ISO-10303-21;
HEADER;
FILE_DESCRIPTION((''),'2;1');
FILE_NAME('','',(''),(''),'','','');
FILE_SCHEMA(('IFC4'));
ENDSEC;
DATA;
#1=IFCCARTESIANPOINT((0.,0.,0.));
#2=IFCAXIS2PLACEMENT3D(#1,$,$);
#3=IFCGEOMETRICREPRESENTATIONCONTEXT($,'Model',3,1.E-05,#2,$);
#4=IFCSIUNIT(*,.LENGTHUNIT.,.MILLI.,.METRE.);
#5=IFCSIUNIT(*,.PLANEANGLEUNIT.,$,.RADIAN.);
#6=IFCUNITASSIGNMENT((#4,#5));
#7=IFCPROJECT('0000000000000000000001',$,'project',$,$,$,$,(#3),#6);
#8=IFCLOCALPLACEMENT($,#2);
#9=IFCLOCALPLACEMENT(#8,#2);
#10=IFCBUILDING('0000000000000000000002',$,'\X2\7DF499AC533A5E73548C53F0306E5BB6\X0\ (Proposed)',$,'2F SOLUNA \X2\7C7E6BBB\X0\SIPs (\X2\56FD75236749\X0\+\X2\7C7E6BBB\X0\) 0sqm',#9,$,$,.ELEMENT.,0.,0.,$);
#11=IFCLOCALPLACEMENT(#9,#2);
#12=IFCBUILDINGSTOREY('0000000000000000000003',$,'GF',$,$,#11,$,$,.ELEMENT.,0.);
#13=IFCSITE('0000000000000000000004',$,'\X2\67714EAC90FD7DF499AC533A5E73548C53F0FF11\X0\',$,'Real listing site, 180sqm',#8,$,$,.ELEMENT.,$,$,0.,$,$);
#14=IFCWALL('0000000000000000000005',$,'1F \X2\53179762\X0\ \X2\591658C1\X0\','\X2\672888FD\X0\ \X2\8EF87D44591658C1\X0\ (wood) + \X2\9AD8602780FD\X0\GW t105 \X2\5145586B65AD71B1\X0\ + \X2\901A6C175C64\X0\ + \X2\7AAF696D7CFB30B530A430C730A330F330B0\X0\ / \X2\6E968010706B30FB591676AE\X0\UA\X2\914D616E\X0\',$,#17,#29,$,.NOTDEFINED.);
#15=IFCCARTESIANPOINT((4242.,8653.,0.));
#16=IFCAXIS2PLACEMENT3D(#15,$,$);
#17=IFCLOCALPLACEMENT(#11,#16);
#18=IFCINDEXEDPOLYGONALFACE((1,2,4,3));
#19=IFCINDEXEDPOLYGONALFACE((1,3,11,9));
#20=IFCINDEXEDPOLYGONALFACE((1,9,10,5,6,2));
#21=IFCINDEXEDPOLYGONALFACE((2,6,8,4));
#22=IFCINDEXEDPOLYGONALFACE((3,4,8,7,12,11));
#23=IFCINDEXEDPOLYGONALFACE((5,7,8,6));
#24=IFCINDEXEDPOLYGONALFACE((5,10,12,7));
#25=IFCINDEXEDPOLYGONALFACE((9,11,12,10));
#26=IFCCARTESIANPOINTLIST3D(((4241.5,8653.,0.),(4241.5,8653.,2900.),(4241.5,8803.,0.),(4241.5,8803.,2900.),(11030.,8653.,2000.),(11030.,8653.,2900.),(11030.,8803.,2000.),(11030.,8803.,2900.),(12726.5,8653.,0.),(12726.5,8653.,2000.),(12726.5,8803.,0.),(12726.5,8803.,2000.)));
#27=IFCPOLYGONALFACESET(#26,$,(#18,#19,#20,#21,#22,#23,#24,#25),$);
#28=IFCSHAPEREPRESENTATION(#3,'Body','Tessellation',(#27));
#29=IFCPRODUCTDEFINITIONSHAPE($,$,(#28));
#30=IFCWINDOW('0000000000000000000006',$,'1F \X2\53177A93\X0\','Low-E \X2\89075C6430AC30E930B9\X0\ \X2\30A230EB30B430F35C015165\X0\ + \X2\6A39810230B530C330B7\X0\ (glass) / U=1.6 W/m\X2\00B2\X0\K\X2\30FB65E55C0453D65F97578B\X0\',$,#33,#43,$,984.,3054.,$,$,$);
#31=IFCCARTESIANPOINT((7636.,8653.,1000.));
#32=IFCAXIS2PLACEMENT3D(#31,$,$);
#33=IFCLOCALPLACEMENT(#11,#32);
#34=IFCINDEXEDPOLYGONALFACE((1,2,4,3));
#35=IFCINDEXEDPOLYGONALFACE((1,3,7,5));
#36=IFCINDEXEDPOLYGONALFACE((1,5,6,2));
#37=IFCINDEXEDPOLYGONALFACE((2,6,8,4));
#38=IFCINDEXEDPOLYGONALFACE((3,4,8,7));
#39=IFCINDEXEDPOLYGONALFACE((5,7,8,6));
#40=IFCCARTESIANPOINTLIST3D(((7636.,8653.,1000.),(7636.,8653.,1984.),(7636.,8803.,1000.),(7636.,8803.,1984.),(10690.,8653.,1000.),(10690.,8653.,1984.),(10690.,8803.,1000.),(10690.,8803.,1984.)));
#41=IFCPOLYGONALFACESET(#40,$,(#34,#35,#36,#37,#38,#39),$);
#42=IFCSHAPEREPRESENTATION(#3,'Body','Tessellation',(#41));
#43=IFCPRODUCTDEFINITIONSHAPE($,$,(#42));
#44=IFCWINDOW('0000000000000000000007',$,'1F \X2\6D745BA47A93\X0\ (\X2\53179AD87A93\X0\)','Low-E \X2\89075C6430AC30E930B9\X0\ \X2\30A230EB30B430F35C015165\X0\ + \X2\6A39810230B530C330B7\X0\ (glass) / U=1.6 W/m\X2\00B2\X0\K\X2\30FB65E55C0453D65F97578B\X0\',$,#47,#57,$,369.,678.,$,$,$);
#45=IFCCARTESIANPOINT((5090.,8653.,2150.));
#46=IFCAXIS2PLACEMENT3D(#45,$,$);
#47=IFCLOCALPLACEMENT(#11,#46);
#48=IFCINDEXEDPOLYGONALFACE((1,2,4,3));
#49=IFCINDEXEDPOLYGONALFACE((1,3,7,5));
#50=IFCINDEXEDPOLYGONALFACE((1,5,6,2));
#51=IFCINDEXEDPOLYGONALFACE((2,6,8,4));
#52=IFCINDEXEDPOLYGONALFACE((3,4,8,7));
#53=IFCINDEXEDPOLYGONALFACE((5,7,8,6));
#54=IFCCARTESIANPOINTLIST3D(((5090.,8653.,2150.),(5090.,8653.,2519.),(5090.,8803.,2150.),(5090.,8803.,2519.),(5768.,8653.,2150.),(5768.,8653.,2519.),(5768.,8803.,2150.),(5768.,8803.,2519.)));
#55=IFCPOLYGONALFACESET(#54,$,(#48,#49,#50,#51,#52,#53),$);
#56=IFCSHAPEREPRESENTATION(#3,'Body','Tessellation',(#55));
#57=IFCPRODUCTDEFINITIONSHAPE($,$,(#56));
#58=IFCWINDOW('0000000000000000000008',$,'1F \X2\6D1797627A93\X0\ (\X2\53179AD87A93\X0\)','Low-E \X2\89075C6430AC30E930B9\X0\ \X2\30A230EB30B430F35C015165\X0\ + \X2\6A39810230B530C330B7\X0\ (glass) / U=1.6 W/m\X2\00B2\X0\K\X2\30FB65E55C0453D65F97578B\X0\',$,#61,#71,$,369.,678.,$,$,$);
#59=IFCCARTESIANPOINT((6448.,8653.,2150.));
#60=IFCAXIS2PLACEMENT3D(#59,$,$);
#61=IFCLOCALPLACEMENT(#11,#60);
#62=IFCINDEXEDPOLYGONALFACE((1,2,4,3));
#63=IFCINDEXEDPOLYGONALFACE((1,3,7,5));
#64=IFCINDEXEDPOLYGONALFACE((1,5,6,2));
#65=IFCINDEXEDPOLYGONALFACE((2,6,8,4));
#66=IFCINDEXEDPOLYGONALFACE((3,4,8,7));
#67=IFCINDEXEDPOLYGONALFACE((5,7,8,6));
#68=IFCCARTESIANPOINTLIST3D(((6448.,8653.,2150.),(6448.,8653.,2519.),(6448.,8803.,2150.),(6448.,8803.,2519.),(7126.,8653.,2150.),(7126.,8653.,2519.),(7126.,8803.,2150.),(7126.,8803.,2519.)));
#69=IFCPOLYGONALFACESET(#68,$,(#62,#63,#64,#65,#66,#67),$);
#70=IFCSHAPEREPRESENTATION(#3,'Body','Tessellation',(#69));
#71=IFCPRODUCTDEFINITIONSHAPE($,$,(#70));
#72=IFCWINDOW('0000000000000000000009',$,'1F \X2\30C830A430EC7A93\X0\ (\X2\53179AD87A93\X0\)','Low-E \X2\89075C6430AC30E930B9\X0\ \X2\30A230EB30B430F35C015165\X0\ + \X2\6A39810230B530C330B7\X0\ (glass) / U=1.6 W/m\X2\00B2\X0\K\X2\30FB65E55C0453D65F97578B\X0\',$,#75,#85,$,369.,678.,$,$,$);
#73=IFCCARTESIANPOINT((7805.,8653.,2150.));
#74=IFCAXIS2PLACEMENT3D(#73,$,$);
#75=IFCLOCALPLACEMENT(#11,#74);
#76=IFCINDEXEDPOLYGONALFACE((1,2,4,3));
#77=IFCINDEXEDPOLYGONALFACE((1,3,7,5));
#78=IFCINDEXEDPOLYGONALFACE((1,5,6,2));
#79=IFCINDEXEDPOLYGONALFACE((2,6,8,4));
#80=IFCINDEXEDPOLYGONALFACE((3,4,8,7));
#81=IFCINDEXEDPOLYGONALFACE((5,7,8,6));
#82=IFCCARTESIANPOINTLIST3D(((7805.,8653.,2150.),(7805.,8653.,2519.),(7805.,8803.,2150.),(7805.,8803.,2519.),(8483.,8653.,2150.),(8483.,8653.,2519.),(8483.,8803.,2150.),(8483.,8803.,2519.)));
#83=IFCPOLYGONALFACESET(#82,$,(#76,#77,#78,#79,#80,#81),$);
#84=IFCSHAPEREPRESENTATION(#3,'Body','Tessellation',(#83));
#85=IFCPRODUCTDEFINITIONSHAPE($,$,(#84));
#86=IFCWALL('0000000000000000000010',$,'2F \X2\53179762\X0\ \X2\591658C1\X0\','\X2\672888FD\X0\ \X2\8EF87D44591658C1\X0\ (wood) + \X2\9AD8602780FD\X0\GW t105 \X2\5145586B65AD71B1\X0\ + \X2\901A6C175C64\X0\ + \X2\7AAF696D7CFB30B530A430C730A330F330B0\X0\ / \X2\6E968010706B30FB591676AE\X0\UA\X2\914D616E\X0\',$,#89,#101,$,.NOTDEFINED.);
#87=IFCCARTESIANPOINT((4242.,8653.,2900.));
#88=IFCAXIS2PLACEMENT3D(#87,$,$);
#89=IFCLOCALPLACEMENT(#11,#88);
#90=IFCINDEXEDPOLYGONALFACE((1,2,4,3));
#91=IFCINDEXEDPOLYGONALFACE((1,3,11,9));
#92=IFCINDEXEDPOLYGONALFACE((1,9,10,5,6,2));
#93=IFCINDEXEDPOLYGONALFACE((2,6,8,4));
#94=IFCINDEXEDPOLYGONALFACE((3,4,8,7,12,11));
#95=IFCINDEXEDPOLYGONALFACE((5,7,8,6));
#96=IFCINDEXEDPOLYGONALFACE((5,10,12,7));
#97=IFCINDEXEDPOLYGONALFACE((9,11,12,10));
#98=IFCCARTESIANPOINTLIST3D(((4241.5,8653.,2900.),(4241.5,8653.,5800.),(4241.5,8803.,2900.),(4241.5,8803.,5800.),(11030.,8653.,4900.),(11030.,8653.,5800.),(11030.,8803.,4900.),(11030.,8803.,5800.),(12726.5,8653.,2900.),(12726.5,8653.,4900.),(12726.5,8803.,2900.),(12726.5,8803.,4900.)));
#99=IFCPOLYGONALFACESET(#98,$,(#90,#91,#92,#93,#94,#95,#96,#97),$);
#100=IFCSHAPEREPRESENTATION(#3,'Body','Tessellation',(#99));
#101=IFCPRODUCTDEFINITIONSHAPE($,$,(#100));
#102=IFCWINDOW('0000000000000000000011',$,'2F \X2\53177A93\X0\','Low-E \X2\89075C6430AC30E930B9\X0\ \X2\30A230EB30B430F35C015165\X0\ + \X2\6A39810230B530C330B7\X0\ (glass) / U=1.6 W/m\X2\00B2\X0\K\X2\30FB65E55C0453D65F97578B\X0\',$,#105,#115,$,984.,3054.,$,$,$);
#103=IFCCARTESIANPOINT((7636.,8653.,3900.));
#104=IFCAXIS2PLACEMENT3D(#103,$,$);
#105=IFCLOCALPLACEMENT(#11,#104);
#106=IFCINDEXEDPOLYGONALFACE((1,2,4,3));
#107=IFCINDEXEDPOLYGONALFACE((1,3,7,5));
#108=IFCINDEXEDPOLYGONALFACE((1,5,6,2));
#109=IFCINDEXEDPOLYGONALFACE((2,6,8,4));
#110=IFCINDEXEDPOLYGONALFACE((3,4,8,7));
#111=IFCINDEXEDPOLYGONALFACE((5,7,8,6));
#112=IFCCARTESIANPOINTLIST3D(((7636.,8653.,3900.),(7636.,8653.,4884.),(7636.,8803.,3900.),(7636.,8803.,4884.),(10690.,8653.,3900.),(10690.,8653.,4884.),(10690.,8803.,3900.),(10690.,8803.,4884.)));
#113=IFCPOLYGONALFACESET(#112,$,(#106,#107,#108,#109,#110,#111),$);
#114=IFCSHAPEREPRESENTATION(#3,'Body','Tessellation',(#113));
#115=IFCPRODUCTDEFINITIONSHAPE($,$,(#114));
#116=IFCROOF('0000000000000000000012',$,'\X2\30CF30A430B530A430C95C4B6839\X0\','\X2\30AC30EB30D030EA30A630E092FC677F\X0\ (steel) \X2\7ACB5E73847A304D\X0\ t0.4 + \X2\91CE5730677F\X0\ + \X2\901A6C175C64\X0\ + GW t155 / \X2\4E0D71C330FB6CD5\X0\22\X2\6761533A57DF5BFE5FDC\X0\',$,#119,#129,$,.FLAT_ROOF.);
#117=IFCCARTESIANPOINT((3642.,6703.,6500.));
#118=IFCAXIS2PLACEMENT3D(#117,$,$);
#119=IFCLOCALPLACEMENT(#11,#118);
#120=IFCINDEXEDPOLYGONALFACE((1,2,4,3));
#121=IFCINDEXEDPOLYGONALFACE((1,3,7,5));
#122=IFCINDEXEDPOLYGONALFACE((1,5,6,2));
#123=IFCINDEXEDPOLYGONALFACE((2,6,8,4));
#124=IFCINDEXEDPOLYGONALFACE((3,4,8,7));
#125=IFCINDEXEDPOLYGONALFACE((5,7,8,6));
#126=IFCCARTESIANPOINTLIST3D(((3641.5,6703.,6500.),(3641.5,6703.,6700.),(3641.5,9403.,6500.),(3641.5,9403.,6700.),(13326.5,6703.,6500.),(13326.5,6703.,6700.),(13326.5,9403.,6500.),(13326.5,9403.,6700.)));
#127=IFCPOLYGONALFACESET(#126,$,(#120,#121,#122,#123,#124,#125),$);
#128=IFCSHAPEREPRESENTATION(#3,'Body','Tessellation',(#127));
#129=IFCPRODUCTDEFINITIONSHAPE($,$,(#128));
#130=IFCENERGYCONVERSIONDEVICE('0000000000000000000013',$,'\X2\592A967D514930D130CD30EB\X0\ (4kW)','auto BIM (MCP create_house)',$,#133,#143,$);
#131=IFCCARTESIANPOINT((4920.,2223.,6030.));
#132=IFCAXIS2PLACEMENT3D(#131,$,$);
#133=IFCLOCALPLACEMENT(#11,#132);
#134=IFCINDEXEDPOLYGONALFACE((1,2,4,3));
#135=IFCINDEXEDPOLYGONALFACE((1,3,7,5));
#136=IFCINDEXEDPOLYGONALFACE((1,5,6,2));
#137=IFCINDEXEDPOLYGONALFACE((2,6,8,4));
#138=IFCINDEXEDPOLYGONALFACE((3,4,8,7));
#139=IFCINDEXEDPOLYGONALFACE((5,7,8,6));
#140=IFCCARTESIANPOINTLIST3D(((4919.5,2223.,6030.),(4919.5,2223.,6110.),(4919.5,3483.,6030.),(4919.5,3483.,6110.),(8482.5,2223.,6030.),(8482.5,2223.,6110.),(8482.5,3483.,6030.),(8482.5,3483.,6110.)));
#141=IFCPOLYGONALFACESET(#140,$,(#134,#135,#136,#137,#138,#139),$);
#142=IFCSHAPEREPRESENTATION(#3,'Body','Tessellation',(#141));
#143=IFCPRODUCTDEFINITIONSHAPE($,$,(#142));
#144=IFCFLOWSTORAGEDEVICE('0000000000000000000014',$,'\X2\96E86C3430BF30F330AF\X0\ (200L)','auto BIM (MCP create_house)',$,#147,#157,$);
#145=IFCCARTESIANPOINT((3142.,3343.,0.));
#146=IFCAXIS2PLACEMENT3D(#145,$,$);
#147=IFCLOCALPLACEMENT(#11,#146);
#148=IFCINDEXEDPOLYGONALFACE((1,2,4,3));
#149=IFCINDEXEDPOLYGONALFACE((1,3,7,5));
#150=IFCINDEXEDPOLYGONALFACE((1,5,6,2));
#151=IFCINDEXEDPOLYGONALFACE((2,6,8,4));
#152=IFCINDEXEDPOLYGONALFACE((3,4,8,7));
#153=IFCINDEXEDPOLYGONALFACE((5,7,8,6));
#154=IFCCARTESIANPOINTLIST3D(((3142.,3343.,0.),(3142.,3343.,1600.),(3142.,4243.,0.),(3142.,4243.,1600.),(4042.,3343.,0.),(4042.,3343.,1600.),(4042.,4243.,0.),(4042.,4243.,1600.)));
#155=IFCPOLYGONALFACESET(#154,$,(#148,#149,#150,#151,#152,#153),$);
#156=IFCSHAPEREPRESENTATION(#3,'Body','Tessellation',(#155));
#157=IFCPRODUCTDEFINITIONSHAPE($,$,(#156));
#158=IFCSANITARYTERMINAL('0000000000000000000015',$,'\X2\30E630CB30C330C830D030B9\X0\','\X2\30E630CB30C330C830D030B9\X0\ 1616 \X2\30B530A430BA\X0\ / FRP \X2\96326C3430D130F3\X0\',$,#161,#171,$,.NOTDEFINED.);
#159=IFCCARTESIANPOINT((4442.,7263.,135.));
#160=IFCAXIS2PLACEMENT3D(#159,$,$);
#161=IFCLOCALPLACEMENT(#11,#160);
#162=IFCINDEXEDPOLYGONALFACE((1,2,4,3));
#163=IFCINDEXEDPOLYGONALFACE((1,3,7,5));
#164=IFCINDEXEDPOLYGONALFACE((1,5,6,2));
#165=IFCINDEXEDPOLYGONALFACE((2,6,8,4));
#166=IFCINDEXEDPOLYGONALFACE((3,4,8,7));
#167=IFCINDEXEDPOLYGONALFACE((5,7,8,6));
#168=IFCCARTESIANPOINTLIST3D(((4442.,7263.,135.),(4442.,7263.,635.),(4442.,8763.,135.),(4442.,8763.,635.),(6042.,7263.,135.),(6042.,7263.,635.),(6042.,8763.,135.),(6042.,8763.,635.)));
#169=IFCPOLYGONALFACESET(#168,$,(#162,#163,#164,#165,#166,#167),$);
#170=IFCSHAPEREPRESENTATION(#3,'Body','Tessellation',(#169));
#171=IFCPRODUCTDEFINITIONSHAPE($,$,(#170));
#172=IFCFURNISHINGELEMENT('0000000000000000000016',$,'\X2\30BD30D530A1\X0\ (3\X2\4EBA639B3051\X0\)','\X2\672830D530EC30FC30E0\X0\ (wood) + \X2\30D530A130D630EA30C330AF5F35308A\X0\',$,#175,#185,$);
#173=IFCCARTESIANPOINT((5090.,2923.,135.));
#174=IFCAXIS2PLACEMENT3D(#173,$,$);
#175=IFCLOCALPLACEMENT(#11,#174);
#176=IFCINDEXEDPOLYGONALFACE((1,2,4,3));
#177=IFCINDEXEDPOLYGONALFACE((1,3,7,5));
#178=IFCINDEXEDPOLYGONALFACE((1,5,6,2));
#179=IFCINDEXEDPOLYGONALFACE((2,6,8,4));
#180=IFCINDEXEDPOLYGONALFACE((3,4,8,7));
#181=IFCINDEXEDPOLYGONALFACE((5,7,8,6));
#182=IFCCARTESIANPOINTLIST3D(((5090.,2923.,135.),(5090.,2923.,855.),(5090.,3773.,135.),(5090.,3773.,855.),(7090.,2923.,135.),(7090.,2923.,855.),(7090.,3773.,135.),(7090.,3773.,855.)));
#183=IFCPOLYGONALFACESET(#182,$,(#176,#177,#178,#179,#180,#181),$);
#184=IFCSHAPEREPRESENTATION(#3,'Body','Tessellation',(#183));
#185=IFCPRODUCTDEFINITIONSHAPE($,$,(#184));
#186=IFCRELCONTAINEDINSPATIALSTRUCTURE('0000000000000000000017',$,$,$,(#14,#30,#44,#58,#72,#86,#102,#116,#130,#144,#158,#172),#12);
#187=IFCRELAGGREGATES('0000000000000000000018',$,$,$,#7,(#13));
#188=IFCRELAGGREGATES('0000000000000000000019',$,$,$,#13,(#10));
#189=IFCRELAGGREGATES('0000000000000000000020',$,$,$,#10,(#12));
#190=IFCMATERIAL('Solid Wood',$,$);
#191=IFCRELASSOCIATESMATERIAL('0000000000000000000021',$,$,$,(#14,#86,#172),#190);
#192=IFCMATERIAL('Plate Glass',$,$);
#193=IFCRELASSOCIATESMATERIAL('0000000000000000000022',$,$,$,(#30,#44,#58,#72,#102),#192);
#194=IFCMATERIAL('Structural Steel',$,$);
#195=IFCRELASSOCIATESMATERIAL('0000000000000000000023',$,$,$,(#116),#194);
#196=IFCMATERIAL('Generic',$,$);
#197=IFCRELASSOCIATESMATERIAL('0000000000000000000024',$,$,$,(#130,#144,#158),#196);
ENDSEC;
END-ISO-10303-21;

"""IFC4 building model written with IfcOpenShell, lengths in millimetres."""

from ifc_helpers import new_model, si_unit, frame, frame_2d, origin, place, context, project, spatial, rectangle, extrude, material, element, fill, save


model = new_model("IFC4")

# Units and contexts
model_context = context("Model", 3, precision=1e-05, world=origin())
ifc_project = project(units=[si_unit("LENGTHUNIT", "METRE", prefix="MILLI"), si_unit("PLANEANGLEUNIT", "RADIAN")], contexts=[model_context])

# Site, building, storey
site_placement = place(None, origin())
site = spatial("IfcSite", under=ifc_project, at=site_placement, Name="東京都練馬区平和台１", ObjectType="Real listing site, 180sqm", CompositionType="ELEMENT", RefElevation=0.0)
building_placement = place(site_placement, origin())
building = spatial("IfcBuilding", under=site, at=building_placement, Name="練馬区平和台の家 (Proposed)", ObjectType="2F SOLUNA 籾殻SIPs (国産杉+籾殻) 0sqm", CompositionType="ELEMENT", ElevationOfRefHeight=0.0, ElevationOfTerrain=0.0)
storey_placement = place(building_placement, origin())
storey = spatial("IfcBuildingStorey", under=building, at=storey_placement, Name="GF", CompositionType="ELEMENT", Elevation=0.0)

# Wall, openings, windows
ifc_material_1 = material(Name="Solid Wood")
wall_1_placement = place(storey_placement, frame((4242.0, 8653.0, 0.0)))
wall_1 = element("IfcWall", 1, at=wall_1_placement, inside=storey, material=ifc_material_1, Name="1F 北面 外壁", Description="木製 軸組外壁 (wood) + 高性能GW t105 充填断熱 + 通気層 + 窯業系サイディング / 準耐火・外皮UA配慮", PredefinedType="NOTDEFINED", context=model_context, shape_type="SweptSolid", body=[
    extrude(rectangle(XDim=8485.0, YDim=150.0, at=frame_2d((4242.0, 75.0))), frame((4242.0, 8653.0, 0.0)), (0.0, 0.0, 1.0), 2900.0),
])
opening_1_placement = place(storey_placement, frame((7636.0, 8653.0, 1000.0)))
opening_1 = element("IfcOpeningElement", 2, at=opening_1_placement, cuts=wall_1, PredefinedType="NOTDEFINED", context=model_context, shape_type="SweptSolid", body=[
    extrude(rectangle(XDim=3054.0, YDim=150.0, at=frame_2d((1527.0, 75.0))), frame((7636.0, 8653.0, 1000.0)), (0.0, 0.0, 1.0), 984.0),
])
opening_2_placement = place(storey_placement, frame((5090.0, 8653.0, 2150.0)))
opening_2 = element("IfcOpeningElement", 3, at=opening_2_placement, cuts=wall_1, PredefinedType="NOTDEFINED", context=model_context, shape_type="SweptSolid", body=[
    extrude(rectangle(XDim=678.0, YDim=150.0, at=frame_2d((339.0, 75.0))), frame((5090.0, 8653.0, 2150.0)), (0.0, 0.0, 1.0), 369.0),
])
opening_3_placement = place(storey_placement, frame((6448.0, 8653.0, 2150.0)))
opening_3 = element("IfcOpeningElement", 4, at=opening_3_placement, cuts=wall_1, PredefinedType="NOTDEFINED", context=model_context, shape_type="SweptSolid", body=[
    extrude(rectangle(XDim=678.0, YDim=150.0, at=frame_2d((339.0, 75.0))), frame((6448.0, 8653.0, 2150.0)), (0.0, 0.0, 1.0), 369.0),
])
opening_4_placement = place(storey_placement, frame((7805.0, 8653.0, 2150.0)))
opening_4 = element("IfcOpeningElement", 5, at=opening_4_placement, cuts=wall_1, PredefinedType="NOTDEFINED", context=model_context, shape_type="SweptSolid", body=[
    extrude(rectangle(XDim=678.0, YDim=150.0, at=frame_2d((339.0, 75.0))), frame((7805.0, 8653.0, 2150.0)), (0.0, 0.0, 1.0), 369.0),
])
ifc_material_2 = material(Name="Plate Glass")
window_1_placement = place(storey_placement, frame((7636.0, 8653.0, 1000.0)))
window_1 = element("IfcWindow", 6, at=window_1_placement, inside=storey, material=ifc_material_2, Name="1F 北窓", Description="Low-E 複層ガラス アルゴン封入 + 樹脂サッシ (glass) / U=1.6 W/m²K・日射取得型", OverallHeight=984.0, OverallWidth=3054.0, context=model_context, shape_type="SweptSolid", body=[
    extrude(rectangle(XDim=3054.0, YDim=150.0, at=frame_2d((1527.0, 75.0))), frame((7636.0, 8653.0, 1000.0)), (0.0, 0.0, 1.0), 984.0),
])
fill(opening_1, window_1)
window_2_placement = place(storey_placement, frame((5090.0, 8653.0, 2150.0)))
window_2 = element("IfcWindow", 7, at=window_2_placement, inside=storey, material=ifc_material_2, Name="1F 浴室窓 (北高窓)", Description="Low-E 複層ガラス アルゴン封入 + 樹脂サッシ (glass) / U=1.6 W/m²K・日射取得型", OverallHeight=369.0, OverallWidth=678.0, context=model_context, shape_type="SweptSolid", body=[
    extrude(rectangle(XDim=678.0, YDim=150.0, at=frame_2d((339.0, 75.0))), frame((5090.0, 8653.0, 2150.0)), (0.0, 0.0, 1.0), 369.0),
])
fill(opening_2, window_2)
window_3_placement = place(storey_placement, frame((6448.0, 8653.0, 2150.0)))
window_3 = element("IfcWindow", 8, at=window_3_placement, inside=storey, material=ifc_material_2, Name="1F 洗面窓 (北高窓)", Description="Low-E 複層ガラス アルゴン封入 + 樹脂サッシ (glass) / U=1.6 W/m²K・日射取得型", OverallHeight=369.0, OverallWidth=678.0, context=model_context, shape_type="SweptSolid", body=[
    extrude(rectangle(XDim=678.0, YDim=150.0, at=frame_2d((339.0, 75.0))), frame((6448.0, 8653.0, 2150.0)), (0.0, 0.0, 1.0), 369.0),
])
fill(opening_3, window_3)
window_4_placement = place(storey_placement, frame((7805.0, 8653.0, 2150.0)))
window_4 = element("IfcWindow", 9, at=window_4_placement, inside=storey, material=ifc_material_2, Name="1F トイレ窓 (北高窓)", Description="Low-E 複層ガラス アルゴン封入 + 樹脂サッシ (glass) / U=1.6 W/m²K・日射取得型", OverallHeight=369.0, OverallWidth=678.0, context=model_context, shape_type="SweptSolid", body=[
    extrude(rectangle(XDim=678.0, YDim=150.0, at=frame_2d((339.0, 75.0))), frame((7805.0, 8653.0, 2150.0)), (0.0, 0.0, 1.0), 369.0),
])
fill(opening_4, window_4)

# Wall, opening, window
wall_2_placement = place(storey_placement, frame((4242.0, 8653.0, 2900.0)))
wall_2 = element("IfcWall", 10, at=wall_2_placement, inside=storey, material=ifc_material_1, Name="2F 北面 外壁", Description="木製 軸組外壁 (wood) + 高性能GW t105 充填断熱 + 通気層 + 窯業系サイディング / 準耐火・外皮UA配慮", PredefinedType="NOTDEFINED", context=model_context, shape_type="SweptSolid", body=[
    extrude(rectangle(XDim=8485.0, YDim=150.0, at=frame_2d((4242.0, 75.0))), frame((4242.0, 8653.0, 2900.0)), (0.0, 0.0, 1.0), 2900.0),
])
opening_5_placement = place(storey_placement, frame((7636.0, 8653.0, 3900.0)))
opening_5 = element("IfcOpeningElement", 11, at=opening_5_placement, cuts=wall_2, PredefinedType="NOTDEFINED", context=model_context, shape_type="SweptSolid", body=[
    extrude(rectangle(XDim=3054.0, YDim=150.0, at=frame_2d((1527.0, 75.0))), frame((7636.0, 8653.0, 3900.0)), (0.0, 0.0, 1.0), 984.0),
])
window_5_placement = place(storey_placement, frame((7636.0, 8653.0, 3900.0)))
window_5 = element("IfcWindow", 12, at=window_5_placement, inside=storey, material=ifc_material_2, Name="2F 北窓", Description="Low-E 複層ガラス アルゴン封入 + 樹脂サッシ (glass) / U=1.6 W/m²K・日射取得型", OverallHeight=984.0, OverallWidth=3054.0, context=model_context, shape_type="SweptSolid", body=[
    extrude(rectangle(XDim=3054.0, YDim=150.0, at=frame_2d((1527.0, 75.0))), frame((7636.0, 8653.0, 3900.0)), (0.0, 0.0, 1.0), 984.0),
])
fill(opening_5, window_5)

# Roof
ifc_material_3 = material(Name="Structural Steel")
roof_placement = place(storey_placement, frame((3642.0, 6703.0, 6500.0)))
element("IfcRoof", 13, at=roof_placement, inside=storey, material=ifc_material_3, Name="ハイサイド屋根", Description="ガルバリウム鋼板 (steel) 立平葺き t0.4 + 野地板 + 通気層 + GW t155 / 不燃・法22条区域対応", PredefinedType="FLAT_ROOF", context=model_context, shape_type="SweptSolid", body=[
    extrude(rectangle(XDim=9685.0, YDim=2700.0, at=frame_2d((4842.0, 1350.0))), frame((3642.0, 6703.0, 6500.0)), (0.0, 0.0, 1.0), 200.0),
])

# Energy conversion device
ifc_material_4 = material(Name="Generic")
energy_conversion_device_placement = place(storey_placement, frame((4920.0, 2223.0, 6030.0)))
element("IfcEnergyConversionDevice", 14, at=energy_conversion_device_placement, inside=storey, material=ifc_material_4, Name="太陽光パネル (4kW)", Description="auto BIM (MCP create_house)", context=model_context, shape_type="SweptSolid", body=[
    extrude(rectangle(XDim=3563.0, YDim=1260.0, at=frame_2d((1781.0, 630.0))), frame((4920.0, 2223.0, 6030.0)), (0.0, 0.0, 1.0), 80.0),
])

# Flow storage device
flow_storage_device_placement = place(storey_placement, frame((3142.0, 3343.0, 0.0)))
element("IfcFlowStorageDevice", 15, at=flow_storage_device_placement, inside=storey, material=ifc_material_4, Name="雨水タンク (200L)", Description="auto BIM (MCP create_house)", context=model_context, shape_type="SweptSolid", body=[
    extrude(rectangle(XDim=900.0, YDim=900.0, at=frame_2d((450.0, 450.0))), frame((3142.0, 3343.0, 0.0)), (0.0, 0.0, 1.0), 1600.0),
])

# Sanitary terminal
sanitary_terminal_placement = place(storey_placement, frame((4442.0, 7263.0, 135.0)))
element("IfcSanitaryTerminal", 16, at=sanitary_terminal_placement, inside=storey, material=ifc_material_4, Name="ユニットバス", Description="ユニットバス 1616 サイズ / FRP 防水パン", PredefinedType="NOTDEFINED", context=model_context, shape_type="SweptSolid", body=[
    extrude(rectangle(XDim=1600.0, YDim=1500.0, at=frame_2d((800.0, 750.0))), frame((4442.0, 7263.0, 135.0)), (0.0, 0.0, 1.0), 500.0),
])

# Furnishing element
furnishing_1_placement = place(storey_placement, frame((5090.0, 2923.0, 135.0)))
element("IfcFurnishingElement", 17, at=furnishing_1_placement, inside=storey, material=ifc_material_1, Name="ソファ (3人掛け)", Description="木フレーム (wood) + ファブリック張り", context=model_context, shape_type="SweptSolid", body=[
    extrude(rectangle(XDim=2000.0, YDim=850.0, at=frame_2d((1000.0, 425.0))), frame((5090.0, 2923.0, 135.0)), (0.0, 0.0, 1.0), 720.0),
])

save(model, "model.ifc")
